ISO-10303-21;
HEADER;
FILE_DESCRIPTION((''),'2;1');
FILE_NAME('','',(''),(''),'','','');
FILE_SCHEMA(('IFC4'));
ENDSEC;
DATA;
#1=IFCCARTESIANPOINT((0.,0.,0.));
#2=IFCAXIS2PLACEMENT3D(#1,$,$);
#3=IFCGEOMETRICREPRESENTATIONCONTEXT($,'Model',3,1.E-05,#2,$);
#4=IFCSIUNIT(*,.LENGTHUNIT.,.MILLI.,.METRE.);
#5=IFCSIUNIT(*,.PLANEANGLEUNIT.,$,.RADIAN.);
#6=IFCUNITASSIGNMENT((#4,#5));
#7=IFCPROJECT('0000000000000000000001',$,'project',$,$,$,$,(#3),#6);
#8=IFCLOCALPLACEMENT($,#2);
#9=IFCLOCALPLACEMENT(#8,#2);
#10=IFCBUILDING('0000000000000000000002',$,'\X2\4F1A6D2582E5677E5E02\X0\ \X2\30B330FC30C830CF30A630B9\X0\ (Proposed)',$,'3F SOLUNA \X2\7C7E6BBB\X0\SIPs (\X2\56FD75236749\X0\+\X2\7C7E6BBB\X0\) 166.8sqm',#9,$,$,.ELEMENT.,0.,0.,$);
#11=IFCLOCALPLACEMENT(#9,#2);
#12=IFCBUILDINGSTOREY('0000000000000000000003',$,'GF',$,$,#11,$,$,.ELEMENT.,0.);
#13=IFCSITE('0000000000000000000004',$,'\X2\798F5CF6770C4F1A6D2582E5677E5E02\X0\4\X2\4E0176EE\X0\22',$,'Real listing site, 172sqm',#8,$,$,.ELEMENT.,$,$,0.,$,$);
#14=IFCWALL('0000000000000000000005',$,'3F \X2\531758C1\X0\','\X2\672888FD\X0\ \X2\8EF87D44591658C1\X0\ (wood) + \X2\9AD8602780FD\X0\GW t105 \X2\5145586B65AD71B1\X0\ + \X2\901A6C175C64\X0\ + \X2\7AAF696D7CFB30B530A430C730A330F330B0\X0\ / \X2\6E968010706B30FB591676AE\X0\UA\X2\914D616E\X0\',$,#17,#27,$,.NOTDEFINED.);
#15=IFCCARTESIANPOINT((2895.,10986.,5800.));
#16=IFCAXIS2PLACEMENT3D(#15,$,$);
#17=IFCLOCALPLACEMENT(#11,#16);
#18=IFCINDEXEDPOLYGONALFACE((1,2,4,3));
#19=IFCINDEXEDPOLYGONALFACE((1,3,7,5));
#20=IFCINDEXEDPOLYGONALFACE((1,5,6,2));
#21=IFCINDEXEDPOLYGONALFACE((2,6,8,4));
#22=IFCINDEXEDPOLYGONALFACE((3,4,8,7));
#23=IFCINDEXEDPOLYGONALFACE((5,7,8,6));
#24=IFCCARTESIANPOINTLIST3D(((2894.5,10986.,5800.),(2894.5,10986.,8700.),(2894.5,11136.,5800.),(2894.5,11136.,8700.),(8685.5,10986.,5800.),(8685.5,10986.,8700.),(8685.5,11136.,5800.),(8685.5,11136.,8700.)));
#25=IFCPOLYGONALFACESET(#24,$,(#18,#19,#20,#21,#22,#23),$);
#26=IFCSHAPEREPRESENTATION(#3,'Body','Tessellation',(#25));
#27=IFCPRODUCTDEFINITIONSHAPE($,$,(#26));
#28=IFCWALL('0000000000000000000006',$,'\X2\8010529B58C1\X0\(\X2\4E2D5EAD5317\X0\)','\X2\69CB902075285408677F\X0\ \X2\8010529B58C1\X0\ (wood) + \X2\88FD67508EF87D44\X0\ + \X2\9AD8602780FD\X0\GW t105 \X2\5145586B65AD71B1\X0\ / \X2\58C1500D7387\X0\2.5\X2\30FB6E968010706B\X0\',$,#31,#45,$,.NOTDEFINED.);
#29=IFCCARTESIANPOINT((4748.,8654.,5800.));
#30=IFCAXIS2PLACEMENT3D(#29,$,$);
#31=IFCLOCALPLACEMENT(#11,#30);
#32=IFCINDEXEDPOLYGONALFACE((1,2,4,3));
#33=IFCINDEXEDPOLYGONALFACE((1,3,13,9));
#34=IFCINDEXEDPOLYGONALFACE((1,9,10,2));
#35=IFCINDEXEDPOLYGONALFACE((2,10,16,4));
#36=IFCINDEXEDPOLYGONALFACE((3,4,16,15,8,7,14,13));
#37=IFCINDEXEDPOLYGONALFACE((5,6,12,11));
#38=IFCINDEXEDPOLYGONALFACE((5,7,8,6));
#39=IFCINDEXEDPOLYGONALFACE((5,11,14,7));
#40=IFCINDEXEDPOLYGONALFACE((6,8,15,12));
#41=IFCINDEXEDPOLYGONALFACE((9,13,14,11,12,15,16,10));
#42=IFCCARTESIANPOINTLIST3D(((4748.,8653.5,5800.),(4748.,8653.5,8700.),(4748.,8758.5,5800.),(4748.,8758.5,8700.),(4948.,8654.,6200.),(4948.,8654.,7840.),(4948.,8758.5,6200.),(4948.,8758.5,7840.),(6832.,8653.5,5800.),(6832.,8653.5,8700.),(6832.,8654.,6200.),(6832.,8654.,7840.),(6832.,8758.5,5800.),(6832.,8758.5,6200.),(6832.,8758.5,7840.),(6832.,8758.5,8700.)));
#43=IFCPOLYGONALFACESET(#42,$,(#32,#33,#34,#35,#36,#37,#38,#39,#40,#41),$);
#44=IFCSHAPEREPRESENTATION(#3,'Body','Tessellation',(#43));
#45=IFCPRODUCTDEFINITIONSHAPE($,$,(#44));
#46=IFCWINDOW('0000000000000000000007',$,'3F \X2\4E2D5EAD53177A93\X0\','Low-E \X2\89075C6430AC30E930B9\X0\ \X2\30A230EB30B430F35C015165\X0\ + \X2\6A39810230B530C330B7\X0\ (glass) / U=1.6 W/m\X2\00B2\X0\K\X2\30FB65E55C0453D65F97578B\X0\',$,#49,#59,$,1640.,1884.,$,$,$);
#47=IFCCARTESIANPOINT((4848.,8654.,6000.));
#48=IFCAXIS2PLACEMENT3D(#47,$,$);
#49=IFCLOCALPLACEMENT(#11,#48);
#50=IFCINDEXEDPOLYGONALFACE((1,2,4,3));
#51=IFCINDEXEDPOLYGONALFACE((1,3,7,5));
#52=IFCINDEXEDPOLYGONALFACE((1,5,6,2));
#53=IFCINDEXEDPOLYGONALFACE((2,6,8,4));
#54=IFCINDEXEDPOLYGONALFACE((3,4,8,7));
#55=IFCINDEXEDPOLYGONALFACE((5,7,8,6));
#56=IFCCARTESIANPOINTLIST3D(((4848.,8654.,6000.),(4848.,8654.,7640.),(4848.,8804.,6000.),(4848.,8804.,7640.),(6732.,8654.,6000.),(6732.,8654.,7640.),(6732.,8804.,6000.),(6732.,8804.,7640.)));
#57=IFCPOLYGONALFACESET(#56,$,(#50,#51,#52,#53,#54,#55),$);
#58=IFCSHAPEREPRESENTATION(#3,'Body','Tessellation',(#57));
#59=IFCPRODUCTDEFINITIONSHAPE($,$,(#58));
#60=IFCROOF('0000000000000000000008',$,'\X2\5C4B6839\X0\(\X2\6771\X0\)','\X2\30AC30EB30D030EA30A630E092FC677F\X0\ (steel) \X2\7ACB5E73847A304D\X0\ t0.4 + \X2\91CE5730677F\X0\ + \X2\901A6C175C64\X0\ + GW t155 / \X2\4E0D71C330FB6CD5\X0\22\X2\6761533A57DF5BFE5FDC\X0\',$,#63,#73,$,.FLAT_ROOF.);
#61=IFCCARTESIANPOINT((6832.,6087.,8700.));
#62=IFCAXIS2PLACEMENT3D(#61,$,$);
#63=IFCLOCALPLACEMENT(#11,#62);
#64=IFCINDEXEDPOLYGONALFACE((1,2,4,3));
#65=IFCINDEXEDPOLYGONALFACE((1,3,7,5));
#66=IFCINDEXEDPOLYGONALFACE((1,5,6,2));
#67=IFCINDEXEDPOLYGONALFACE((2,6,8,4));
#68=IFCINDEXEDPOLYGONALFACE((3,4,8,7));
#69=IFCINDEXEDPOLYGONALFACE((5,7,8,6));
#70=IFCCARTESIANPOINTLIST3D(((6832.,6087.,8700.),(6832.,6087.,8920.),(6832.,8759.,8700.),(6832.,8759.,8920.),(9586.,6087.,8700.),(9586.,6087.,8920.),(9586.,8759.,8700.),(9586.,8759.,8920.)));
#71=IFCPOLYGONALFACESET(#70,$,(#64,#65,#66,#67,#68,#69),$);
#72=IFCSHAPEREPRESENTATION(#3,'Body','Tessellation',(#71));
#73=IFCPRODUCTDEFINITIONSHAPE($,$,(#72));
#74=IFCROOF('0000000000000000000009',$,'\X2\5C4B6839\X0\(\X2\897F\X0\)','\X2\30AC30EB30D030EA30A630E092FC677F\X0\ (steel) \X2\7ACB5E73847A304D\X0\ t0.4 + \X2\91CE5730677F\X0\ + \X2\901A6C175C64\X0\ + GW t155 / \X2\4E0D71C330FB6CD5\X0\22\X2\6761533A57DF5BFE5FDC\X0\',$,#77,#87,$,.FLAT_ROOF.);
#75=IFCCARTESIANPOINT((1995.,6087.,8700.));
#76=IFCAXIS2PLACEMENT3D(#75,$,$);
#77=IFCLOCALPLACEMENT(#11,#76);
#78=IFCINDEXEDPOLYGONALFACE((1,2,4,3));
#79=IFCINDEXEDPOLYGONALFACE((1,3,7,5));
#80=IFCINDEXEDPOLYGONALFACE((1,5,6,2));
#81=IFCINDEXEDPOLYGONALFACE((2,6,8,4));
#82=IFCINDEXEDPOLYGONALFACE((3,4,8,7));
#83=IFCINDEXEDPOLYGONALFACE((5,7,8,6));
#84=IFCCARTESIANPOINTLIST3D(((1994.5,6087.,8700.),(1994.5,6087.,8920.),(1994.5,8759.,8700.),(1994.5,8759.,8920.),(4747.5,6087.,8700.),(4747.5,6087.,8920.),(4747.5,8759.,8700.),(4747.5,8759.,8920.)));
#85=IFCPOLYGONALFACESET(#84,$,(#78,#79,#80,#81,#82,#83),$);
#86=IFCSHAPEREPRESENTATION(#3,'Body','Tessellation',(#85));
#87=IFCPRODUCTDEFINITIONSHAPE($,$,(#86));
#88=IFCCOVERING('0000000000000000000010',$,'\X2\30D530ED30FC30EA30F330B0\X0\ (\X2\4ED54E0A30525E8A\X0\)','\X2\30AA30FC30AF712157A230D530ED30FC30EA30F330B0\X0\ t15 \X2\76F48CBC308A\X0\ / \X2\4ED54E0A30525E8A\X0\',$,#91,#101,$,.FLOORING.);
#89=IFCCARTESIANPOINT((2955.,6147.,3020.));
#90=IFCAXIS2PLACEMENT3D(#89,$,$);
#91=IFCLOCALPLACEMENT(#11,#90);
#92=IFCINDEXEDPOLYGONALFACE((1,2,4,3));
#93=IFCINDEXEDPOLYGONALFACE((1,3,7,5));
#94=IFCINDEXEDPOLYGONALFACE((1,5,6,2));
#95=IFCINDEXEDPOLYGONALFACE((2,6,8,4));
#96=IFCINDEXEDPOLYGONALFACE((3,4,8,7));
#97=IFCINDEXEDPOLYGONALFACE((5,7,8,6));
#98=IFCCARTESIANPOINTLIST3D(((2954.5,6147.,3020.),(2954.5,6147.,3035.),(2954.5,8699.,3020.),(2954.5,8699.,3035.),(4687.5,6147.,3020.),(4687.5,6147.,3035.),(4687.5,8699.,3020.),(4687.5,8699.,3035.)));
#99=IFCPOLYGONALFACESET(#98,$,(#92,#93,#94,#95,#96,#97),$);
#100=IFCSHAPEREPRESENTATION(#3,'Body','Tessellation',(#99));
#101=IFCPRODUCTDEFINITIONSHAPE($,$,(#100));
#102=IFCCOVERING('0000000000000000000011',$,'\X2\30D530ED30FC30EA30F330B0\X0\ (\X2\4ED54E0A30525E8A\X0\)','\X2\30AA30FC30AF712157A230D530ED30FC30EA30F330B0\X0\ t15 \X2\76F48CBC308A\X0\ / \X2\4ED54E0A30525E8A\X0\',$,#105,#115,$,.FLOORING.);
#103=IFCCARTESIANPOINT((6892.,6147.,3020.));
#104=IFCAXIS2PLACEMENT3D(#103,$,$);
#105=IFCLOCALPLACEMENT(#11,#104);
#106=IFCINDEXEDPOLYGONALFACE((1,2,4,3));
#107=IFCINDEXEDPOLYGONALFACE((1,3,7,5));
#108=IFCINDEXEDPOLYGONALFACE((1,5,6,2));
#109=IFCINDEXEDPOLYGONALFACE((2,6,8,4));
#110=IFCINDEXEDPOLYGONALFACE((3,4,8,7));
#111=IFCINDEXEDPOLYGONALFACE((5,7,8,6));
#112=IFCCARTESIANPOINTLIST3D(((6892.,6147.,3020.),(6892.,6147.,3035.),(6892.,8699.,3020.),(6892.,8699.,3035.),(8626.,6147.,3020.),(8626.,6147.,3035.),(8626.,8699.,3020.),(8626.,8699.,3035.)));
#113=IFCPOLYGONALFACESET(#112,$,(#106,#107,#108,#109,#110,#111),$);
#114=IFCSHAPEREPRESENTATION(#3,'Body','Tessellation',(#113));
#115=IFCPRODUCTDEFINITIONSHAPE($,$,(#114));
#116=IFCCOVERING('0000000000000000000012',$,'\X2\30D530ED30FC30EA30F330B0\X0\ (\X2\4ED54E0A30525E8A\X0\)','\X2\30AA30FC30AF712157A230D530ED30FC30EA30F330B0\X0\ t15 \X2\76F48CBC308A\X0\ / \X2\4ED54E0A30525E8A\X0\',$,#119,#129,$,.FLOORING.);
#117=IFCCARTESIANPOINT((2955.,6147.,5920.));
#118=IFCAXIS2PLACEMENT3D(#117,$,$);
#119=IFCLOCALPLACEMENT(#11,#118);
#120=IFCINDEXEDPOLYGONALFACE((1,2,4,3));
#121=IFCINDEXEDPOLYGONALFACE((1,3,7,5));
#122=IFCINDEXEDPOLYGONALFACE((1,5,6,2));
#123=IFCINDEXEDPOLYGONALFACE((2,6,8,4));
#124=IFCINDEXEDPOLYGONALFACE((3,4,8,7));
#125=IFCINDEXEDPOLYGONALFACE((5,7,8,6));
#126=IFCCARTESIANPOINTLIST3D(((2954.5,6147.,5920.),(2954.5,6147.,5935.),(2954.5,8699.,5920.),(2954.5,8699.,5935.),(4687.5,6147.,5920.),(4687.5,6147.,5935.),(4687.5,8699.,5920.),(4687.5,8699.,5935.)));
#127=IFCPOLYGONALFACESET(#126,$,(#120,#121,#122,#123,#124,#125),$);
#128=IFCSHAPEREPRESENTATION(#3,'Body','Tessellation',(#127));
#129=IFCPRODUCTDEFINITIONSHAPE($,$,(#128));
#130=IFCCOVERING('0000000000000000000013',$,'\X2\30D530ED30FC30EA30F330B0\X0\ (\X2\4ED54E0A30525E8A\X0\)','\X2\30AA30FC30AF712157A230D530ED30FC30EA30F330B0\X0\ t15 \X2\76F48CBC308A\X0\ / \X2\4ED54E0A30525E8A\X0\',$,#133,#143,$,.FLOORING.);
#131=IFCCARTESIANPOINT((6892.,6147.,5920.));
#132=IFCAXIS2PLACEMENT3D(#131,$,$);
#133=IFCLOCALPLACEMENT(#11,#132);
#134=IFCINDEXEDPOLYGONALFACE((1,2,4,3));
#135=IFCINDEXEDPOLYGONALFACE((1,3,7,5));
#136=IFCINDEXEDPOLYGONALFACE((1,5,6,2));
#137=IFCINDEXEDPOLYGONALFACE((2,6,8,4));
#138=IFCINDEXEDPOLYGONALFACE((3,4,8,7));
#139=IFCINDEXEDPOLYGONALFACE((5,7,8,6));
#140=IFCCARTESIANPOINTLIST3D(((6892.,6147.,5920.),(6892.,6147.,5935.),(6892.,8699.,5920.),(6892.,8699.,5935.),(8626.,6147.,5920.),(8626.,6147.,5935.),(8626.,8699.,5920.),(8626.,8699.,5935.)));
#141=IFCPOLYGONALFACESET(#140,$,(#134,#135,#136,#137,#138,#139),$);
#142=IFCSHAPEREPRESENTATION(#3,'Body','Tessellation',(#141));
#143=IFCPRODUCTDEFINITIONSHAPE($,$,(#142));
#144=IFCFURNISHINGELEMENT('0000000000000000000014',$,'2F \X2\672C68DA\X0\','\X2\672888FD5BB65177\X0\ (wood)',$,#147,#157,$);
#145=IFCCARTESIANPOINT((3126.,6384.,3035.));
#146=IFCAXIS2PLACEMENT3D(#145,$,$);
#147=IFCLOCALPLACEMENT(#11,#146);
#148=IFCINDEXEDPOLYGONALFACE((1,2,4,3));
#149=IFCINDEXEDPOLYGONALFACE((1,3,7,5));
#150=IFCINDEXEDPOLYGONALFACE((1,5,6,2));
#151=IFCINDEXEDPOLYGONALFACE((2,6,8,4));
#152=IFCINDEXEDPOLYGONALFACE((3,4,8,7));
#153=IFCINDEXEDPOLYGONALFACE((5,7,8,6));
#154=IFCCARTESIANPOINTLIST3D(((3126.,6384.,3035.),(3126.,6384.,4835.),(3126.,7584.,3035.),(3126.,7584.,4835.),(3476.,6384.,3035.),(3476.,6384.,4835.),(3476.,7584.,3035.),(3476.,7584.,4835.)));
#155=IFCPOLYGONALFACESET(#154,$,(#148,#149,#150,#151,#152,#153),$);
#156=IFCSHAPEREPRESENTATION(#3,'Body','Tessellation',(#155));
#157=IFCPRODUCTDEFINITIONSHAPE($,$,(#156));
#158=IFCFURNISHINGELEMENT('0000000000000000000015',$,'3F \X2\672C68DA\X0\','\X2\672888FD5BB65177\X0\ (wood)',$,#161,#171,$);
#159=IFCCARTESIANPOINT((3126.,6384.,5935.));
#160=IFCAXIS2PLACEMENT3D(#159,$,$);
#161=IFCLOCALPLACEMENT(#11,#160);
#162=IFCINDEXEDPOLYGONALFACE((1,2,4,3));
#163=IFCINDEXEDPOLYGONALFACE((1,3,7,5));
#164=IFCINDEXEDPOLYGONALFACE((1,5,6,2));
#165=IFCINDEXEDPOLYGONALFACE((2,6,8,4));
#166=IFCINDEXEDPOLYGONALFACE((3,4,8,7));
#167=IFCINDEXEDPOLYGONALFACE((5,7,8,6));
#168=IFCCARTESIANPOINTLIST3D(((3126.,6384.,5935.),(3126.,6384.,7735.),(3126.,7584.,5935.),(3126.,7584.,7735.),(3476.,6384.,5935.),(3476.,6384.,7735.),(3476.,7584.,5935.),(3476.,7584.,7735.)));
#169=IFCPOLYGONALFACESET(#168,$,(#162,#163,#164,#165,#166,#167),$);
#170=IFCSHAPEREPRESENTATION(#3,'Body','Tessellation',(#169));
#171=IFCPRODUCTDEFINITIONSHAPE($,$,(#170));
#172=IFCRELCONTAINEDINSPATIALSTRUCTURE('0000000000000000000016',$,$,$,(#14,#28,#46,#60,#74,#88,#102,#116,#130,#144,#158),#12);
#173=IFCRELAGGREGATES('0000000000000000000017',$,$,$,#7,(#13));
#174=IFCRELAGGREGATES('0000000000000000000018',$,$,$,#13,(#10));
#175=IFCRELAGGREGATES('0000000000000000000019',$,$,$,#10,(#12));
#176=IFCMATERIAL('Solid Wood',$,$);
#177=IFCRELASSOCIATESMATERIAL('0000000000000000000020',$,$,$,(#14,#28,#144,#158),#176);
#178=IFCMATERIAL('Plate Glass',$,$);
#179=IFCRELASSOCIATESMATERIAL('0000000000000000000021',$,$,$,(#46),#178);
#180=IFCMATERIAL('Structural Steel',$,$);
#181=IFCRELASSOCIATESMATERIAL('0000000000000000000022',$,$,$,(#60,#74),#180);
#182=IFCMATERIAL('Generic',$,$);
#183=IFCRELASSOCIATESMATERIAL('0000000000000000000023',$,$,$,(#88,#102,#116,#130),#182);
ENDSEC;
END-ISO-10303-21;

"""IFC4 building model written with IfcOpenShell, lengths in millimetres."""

from ifc_helpers import new_model, si_unit, frame, frame_2d, origin, place, context, project, spatial, rectangle, extrude, material, element, fill, save


model = new_model("IFC4")

# Units and contexts
model_context = context("Model", 3, precision=1e-05, world=origin())
ifc_project = project(units=[si_unit("LENGTHUNIT", "METRE", prefix="MILLI"), si_unit("PLANEANGLEUNIT", "RADIAN")], contexts=[model_context])

# Site, building, storey
site_placement = place(None, origin())
site = spatial("IfcSite", under=ifc_project, at=site_placement, Name="福島県会津若松市4丁目22", ObjectType="Real listing site, 172sqm", CompositionType="ELEMENT", RefElevation=0.0)
building_placement = place(site_placement, origin())
building = spatial("IfcBuilding", under=site, at=building_placement, Name="会津若松市 コートハウス (Proposed)", ObjectType="3F SOLUNA 籾殻SIPs (国産杉+籾殻) 166.8sqm", CompositionType="ELEMENT", ElevationOfRefHeight=0.0, ElevationOfTerrain=0.0)
storey_placement = place(building_placement, origin())
storey = spatial("IfcBuildingStorey", under=building, at=storey_placement, Name="GF", CompositionType="ELEMENT", Elevation=0.0)

# Shared definitions
ifc_material_1 = material(Name="Solid Wood")

# Wall
wall_1_placement = place(storey_placement, frame((2895.0, 10986.0, 5800.0)))
element("IfcWall", 1, at=wall_1_placement, inside=storey, material=ifc_material_1, Name="3F 北壁", Description="木製 軸組外壁 (wood) + 高性能GW t105 充填断熱 + 通気層 + 窯業系サイディング / 準耐火・外皮UA配慮", PredefinedType="NOTDEFINED", context=model_context, shape_type="SweptSolid", body=[
    extrude(rectangle(XDim=5791.0, YDim=150.0, at=frame_2d((2895.0, 75.0))), frame((2895.0, 10986.0, 5800.0)), (0.0, 0.0, 1.0), 2900.0),
])

# Wall, opening, window
wall_2_placement = place(storey_placement, frame((4748.0, 8654.0, 5800.0)))
wall_2 = element("IfcWall", 2, at=wall_2_placement, inside=storey, material=ifc_material_1, Name="耐力壁(中庭北)", Description="構造用合板 耐力壁 (wood) + 製材軸組 + 高性能GW t105 充填断熱 / 壁倍率2.5・準耐火", PredefinedType="NOTDEFINED", context=model_context, shape_type="SweptSolid", body=[
    extrude(rectangle(XDim=2084.0, YDim=105.0, at=frame_2d((1042.0, 52.0))), frame((4748.0, 8654.0, 5800.0)), (0.0, 0.0, 1.0), 2900.0),
])
opening_placement = place(storey_placement, frame((4848.0, 8654.0, 6000.0)))
opening = element("IfcOpeningElement", 3, at=opening_placement, cuts=wall_2, PredefinedType="NOTDEFINED", context=model_context, shape_type="SweptSolid", body=[
    extrude(rectangle(XDim=1884.0, YDim=150.0, at=frame_2d((942.0, 75.0))), frame((4848.0, 8654.0, 6000.0)), (0.0, 0.0, 1.0), 1640.0),
])
ifc_material_2 = material(Name="Plate Glass")
window_1_placement = place(storey_placement, frame((4848.0, 8654.0, 6000.0)))
window_1 = element("IfcWindow", 4, at=window_1_placement, inside=storey, material=ifc_material_2, Name="3F 中庭北窓", Description="Low-E 複層ガラス アルゴン封入 + 樹脂サッシ (glass) / U=1.6 W/m²K・日射取得型", OverallHeight=1640.0, OverallWidth=1884.0, context=model_context, shape_type="SweptSolid", body=[
    extrude(rectangle(XDim=1884.0, YDim=150.0, at=frame_2d((942.0, 75.0))), frame((4848.0, 8654.0, 6000.0)), (0.0, 0.0, 1.0), 1640.0),
])
fill(opening, window_1)

# Shared definitions
ifc_material_3 = material(Name="Generic")

# Roofs
ifc_material_4 = material(Name="Structural Steel")
roof_1_placement = place(storey_placement, frame((6832.0, 6087.0, 8700.0)))
element("IfcRoof", 5, at=roof_1_placement, inside=storey, material=ifc_material_4, Name="屋根(東)", Description="ガルバリウム鋼板 (steel) 立平葺き t0.4 + 野地板 + 通気層 + GW t155 / 不燃・法22条区域対応", PredefinedType="FLAT_ROOF", context=model_context, shape_type="SweptSolid", body=[
    extrude(rectangle(XDim=2754.0, YDim=2672.0, at=frame_2d((1377.0, 1336.0))), frame((6832.0, 6087.0, 8700.0)), (0.0, 0.0, 1.0), 220.0),
])
roof_2_placement = place(storey_placement, frame((1995.0, 6087.0, 8700.0)))
element("IfcRoof", 6, at=roof_2_placement, inside=storey, material=ifc_material_4, Name="屋根(西)", Description="ガルバリウム鋼板 (steel) 立平葺き t0.4 + 野地板 + 通気層 + GW t155 / 不燃・法22条区域対応", PredefinedType="FLAT_ROOF", context=model_context, shape_type="SweptSolid", body=[
    extrude(rectangle(XDim=2753.0, YDim=2672.0, at=frame_2d((1376.0, 1336.0))), frame((1995.0, 6087.0, 8700.0)), (0.0, 0.0, 1.0), 220.0),
])

# Coverings
covering_1_placement = place(storey_placement, frame((2955.0, 6147.0, 3020.0)))
element("IfcCovering", 7, at=covering_1_placement, inside=storey, material=ifc_material_3, Name="フローリング (仕上げ床)", Description="オーク無垢フローリング t15 直貼り / 仕上げ床", PredefinedType="FLOORING", context=model_context, shape_type="SweptSolid", body=[
    extrude(rectangle(XDim=1733.0, YDim=2552.0, at=frame_2d((866.0, 1276.0))), frame((2955.0, 6147.0, 3020.0)), (0.0, 0.0, 1.0), 15.0),
])
covering_2_placement = place(storey_placement, frame((6892.0, 6147.0, 3020.0)))
element("IfcCovering", 8, at=covering_2_placement, inside=storey, material=ifc_material_3, Name="フローリング (仕上げ床)", Description="オーク無垢フローリング t15 直貼り / 仕上げ床", PredefinedType="FLOORING", context=model_context, shape_type="SweptSolid", body=[
    extrude(rectangle(XDim=1734.0, YDim=2552.0, at=frame_2d((867.0, 1276.0))), frame((6892.0, 6147.0, 3020.0)), (0.0, 0.0, 1.0), 15.0),
])
covering_3_placement = place(storey_placement, frame((2955.0, 6147.0, 5920.0)))
element("IfcCovering", 9, at=covering_3_placement, inside=storey, material=ifc_material_3, Name="フローリング (仕上げ床)", Description="オーク無垢フローリング t15 直貼り / 仕上げ床", PredefinedType="FLOORING", context=model_context, shape_type="SweptSolid", body=[
    extrude(rectangle(XDim=1733.0, YDim=2552.0, at=frame_2d((866.0, 1276.0))), frame((2955.0, 6147.0, 5920.0)), (0.0, 0.0, 1.0), 15.0),
])
covering_4_placement = place(storey_placement, frame((6892.0, 6147.0, 5920.0)))
element("IfcCovering", 10, at=covering_4_placement, inside=storey, material=ifc_material_3, Name="フローリング (仕上げ床)", Description="オーク無垢フローリング t15 直貼り / 仕上げ床", PredefinedType="FLOORING", context=model_context, shape_type="SweptSolid", body=[
    extrude(rectangle(XDim=1734.0, YDim=2552.0, at=frame_2d((867.0, 1276.0))), frame((6892.0, 6147.0, 5920.0)), (0.0, 0.0, 1.0), 15.0),
])

# Furnishing elements
furnishing_1_placement = place(storey_placement, frame((3126.0, 6384.0, 3035.0)))
element("IfcFurnishingElement", 11, at=furnishing_1_placement, inside=storey, material=ifc_material_1, Name="2F 本棚", Description="木製家具 (wood)", context=model_context, shape_type="SweptSolid", body=[
    extrude(rectangle(XDim=350.0, YDim=1200.0, at=frame_2d((175.0, 600.0))), frame((3126.0, 6384.0, 3035.0)), (0.0, 0.0, 1.0), 1800.0),
])
furnishing_2_placement = place(storey_placement, frame((3126.0, 6384.0, 5935.0)))
element("IfcFurnishingElement", 12, at=furnishing_2_placement, inside=storey, material=ifc_material_1, Name="3F 本棚", Description="木製家具 (wood)", context=model_context, shape_type="SweptSolid", body=[
    extrude(rectangle(XDim=350.0, YDim=1200.0, at=frame_2d((175.0, 600.0))), frame((3126.0, 6384.0, 5935.0)), (0.0, 0.0, 1.0), 1800.0),
])

save(model, "model.ifc")
